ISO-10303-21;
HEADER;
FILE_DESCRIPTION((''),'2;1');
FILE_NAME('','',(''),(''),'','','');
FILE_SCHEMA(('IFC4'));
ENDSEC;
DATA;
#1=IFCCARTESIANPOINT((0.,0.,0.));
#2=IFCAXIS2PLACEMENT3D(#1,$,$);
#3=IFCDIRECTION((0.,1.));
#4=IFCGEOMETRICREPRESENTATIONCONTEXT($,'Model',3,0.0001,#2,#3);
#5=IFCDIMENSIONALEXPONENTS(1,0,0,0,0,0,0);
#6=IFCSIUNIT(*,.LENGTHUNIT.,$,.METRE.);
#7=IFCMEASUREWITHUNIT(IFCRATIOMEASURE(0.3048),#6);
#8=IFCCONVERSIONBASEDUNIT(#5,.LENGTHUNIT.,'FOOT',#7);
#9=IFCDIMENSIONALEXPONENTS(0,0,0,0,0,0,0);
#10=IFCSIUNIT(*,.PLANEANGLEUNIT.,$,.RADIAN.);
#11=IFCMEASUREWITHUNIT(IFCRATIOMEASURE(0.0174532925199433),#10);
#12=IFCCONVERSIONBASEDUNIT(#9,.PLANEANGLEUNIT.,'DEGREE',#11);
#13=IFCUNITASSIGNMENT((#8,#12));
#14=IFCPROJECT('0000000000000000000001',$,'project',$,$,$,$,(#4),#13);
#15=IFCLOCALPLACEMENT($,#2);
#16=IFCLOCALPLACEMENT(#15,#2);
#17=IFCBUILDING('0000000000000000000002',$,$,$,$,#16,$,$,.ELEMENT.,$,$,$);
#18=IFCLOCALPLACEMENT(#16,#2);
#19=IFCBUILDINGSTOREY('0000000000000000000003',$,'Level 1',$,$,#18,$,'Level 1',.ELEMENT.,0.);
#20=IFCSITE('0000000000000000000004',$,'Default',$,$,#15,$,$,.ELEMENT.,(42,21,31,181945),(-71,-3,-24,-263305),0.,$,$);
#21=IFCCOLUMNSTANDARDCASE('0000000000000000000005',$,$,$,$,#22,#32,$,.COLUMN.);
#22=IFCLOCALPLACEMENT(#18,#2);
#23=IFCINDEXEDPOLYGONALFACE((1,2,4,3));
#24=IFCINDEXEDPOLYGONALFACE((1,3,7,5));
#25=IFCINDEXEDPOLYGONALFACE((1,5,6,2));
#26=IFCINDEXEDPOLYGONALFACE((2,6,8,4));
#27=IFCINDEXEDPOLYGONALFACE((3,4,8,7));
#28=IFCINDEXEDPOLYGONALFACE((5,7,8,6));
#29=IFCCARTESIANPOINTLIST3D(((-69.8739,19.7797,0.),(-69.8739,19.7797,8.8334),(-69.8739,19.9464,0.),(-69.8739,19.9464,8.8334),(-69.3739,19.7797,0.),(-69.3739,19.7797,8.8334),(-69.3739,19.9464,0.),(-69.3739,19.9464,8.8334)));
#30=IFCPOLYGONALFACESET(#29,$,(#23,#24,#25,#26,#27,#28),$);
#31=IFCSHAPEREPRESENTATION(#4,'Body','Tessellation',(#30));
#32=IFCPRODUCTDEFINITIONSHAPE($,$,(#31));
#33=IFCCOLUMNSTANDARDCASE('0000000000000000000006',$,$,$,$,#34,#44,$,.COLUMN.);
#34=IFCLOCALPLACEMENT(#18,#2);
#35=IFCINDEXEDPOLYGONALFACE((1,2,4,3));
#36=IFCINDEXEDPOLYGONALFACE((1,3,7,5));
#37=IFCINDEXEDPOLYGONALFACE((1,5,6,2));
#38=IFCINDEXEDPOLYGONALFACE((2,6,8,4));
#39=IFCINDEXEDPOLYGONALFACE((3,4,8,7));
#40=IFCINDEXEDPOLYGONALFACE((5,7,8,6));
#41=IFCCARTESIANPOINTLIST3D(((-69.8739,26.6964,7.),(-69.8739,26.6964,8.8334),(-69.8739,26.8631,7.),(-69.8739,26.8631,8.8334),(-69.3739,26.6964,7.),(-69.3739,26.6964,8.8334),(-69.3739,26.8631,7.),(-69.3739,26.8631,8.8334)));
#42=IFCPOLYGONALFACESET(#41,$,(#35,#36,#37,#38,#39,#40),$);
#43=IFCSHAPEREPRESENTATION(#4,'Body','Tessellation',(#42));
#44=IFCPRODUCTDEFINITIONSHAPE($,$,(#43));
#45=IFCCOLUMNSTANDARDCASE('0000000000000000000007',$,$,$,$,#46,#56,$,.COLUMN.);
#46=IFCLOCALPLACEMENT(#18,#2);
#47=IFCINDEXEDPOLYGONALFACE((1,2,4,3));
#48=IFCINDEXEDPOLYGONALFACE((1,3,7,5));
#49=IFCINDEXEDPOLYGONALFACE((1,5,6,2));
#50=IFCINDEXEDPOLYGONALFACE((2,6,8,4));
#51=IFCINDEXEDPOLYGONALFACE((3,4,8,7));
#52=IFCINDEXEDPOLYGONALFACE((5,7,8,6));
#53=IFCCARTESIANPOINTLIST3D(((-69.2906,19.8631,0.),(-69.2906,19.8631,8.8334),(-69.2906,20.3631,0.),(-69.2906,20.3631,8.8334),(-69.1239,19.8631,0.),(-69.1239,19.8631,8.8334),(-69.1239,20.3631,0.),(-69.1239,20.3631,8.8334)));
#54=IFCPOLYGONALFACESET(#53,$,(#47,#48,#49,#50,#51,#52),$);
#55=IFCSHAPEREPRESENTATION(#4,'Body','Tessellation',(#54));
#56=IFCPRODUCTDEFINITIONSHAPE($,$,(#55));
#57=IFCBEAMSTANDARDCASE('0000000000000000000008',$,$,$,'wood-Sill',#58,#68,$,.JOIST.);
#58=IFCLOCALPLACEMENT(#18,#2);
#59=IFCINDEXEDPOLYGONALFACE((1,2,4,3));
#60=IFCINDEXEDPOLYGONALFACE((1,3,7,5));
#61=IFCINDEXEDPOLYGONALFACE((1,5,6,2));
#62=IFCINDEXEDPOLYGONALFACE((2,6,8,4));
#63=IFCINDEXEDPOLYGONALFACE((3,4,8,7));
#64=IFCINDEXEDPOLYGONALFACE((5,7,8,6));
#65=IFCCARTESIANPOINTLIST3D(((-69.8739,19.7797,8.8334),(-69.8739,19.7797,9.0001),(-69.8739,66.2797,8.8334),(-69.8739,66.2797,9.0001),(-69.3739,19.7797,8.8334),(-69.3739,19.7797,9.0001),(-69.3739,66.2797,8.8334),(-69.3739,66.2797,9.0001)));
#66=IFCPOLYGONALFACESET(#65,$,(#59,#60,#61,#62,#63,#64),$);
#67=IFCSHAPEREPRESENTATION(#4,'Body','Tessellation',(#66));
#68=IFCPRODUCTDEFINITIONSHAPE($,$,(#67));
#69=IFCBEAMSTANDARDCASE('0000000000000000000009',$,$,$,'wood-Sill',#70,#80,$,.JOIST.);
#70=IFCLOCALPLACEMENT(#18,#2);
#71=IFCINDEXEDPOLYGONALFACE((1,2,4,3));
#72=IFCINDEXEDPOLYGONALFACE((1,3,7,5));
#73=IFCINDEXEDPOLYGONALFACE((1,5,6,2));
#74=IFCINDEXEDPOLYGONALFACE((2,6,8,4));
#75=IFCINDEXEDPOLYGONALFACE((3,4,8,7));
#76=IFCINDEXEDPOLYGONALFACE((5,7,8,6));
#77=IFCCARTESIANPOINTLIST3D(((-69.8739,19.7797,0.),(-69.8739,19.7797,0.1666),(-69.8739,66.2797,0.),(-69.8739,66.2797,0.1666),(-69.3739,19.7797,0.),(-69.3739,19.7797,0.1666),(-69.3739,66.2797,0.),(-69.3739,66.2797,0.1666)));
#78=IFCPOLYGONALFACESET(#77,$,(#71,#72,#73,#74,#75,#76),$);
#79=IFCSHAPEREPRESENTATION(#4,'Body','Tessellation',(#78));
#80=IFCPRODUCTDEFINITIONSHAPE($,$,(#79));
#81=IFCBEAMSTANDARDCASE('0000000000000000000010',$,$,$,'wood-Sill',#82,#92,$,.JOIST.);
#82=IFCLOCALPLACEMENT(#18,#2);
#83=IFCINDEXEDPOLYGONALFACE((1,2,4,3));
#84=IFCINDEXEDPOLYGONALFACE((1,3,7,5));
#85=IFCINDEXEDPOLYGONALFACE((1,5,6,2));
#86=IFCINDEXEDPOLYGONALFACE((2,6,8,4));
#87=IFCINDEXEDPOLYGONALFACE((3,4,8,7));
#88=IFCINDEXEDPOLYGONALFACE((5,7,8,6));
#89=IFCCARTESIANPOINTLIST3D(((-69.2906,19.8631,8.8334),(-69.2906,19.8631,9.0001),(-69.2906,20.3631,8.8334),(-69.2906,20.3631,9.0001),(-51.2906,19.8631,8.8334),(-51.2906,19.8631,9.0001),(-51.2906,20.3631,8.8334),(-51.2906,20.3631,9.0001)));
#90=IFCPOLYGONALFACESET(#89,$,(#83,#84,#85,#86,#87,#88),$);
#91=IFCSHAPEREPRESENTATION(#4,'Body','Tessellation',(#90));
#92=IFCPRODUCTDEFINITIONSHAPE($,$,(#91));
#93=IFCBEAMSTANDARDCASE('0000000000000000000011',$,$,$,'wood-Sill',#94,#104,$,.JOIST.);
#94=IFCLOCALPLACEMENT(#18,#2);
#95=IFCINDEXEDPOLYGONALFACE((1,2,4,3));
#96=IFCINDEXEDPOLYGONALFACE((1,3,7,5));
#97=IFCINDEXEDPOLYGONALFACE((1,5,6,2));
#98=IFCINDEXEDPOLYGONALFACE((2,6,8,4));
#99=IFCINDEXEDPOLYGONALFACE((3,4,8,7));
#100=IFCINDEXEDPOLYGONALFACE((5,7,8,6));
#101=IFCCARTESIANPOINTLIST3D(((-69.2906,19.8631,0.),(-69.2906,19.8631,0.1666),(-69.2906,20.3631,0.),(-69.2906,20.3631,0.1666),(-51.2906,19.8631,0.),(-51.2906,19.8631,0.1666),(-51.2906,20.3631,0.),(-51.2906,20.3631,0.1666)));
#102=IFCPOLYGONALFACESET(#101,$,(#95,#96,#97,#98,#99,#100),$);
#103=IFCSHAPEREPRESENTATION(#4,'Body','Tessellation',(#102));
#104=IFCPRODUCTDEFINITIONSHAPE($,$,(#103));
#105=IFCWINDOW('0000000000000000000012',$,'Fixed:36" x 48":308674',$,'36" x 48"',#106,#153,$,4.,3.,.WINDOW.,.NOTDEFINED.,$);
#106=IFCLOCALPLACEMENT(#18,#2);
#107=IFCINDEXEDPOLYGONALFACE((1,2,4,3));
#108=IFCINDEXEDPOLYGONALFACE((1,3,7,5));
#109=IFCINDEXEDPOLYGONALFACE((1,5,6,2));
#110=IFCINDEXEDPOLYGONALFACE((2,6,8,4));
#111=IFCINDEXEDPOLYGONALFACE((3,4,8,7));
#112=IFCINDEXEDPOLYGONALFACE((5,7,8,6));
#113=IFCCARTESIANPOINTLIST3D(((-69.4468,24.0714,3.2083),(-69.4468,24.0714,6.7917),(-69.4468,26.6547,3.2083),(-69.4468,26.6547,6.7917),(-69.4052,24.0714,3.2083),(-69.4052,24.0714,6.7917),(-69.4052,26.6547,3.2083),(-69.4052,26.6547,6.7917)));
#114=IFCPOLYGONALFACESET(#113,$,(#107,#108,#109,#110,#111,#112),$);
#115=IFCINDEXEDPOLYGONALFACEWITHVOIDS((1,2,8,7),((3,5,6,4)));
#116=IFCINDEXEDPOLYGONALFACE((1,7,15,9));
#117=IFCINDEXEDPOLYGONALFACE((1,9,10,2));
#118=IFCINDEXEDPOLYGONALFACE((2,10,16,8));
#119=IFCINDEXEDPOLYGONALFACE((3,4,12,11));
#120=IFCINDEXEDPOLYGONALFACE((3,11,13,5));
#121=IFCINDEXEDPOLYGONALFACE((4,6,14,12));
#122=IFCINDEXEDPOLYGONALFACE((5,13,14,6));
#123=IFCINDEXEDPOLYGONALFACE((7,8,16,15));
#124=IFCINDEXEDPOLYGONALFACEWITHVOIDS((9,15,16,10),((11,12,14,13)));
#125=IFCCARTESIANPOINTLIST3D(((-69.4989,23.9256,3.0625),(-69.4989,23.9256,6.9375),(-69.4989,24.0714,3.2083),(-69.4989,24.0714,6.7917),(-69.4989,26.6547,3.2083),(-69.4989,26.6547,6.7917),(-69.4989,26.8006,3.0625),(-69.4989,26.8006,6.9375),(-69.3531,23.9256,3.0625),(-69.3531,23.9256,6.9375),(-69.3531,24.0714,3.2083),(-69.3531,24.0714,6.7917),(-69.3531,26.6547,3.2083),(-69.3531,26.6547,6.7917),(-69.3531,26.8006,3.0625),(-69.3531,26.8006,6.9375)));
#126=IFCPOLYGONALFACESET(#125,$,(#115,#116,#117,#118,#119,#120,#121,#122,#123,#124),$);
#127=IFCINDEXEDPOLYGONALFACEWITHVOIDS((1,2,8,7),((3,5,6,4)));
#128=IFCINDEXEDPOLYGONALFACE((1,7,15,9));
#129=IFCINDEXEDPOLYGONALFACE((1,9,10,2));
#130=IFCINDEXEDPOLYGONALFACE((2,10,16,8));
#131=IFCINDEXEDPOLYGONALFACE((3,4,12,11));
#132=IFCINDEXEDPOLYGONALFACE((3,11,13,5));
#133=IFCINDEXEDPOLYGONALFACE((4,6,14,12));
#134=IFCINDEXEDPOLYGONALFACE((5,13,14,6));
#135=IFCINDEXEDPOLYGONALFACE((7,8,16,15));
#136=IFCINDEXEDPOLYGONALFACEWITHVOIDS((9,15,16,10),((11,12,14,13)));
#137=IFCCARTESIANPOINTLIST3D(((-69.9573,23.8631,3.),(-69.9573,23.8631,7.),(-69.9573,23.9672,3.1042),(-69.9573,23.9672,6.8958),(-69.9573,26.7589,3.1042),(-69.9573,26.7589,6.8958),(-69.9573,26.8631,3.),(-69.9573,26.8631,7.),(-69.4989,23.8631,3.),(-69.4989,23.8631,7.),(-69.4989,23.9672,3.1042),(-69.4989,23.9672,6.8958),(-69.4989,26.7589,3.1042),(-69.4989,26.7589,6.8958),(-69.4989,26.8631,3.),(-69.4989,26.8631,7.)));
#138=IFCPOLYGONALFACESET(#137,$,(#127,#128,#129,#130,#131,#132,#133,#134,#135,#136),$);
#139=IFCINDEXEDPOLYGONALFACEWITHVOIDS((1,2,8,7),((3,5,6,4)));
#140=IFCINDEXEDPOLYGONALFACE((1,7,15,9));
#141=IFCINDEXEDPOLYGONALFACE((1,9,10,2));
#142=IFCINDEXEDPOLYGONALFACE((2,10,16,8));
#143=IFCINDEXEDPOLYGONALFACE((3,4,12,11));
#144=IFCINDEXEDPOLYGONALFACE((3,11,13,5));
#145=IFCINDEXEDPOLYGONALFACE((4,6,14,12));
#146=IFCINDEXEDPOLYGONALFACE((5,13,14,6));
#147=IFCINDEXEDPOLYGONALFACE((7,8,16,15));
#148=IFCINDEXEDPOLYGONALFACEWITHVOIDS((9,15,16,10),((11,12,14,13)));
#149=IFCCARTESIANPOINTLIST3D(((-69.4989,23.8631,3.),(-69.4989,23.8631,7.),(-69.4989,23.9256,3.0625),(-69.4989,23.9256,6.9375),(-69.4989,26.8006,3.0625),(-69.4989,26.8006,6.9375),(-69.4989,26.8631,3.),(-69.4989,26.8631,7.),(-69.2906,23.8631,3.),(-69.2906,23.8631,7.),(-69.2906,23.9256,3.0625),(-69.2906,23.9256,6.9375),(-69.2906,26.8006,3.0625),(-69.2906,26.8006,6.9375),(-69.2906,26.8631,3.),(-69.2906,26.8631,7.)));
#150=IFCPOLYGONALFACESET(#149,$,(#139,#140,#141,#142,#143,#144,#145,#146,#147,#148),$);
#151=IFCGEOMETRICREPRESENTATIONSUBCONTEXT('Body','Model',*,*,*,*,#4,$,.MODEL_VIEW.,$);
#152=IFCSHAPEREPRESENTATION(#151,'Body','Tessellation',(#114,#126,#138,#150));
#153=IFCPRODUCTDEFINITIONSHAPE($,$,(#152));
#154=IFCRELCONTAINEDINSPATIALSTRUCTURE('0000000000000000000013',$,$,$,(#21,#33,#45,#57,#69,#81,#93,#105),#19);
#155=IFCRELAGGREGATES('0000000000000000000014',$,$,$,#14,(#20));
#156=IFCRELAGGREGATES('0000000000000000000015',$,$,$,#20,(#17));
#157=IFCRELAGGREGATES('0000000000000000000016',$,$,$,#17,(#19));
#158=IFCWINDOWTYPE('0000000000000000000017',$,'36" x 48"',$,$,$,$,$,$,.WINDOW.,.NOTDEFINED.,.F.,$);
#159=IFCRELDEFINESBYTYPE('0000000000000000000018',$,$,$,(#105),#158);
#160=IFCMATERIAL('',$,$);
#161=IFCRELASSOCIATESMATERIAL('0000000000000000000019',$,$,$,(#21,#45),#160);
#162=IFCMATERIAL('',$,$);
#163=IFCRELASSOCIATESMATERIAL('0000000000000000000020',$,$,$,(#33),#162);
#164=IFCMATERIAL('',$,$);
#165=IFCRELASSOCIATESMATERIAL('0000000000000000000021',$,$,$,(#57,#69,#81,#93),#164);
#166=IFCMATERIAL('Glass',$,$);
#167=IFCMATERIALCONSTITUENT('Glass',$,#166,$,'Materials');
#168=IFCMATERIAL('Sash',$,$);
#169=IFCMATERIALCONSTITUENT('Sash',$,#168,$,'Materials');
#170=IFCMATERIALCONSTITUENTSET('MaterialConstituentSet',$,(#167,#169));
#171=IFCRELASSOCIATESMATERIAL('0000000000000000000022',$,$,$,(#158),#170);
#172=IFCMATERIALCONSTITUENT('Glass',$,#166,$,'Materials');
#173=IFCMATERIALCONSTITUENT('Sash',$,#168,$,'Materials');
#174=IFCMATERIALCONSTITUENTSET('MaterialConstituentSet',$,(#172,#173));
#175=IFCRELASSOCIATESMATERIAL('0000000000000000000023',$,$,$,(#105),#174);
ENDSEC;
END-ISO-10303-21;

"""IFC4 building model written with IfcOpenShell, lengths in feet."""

from ifc_helpers import new_model, entity, si_unit, converted_unit, direction, frame, frame_2d, origin, origin_with_axes, place, context, subcontext, project, spatial, polyline, rectangle, outline, extrude, source, transform, mapped, material, constituent, constituent_set, type_object, type_shapes, element, save


model = new_model("IFC4")

# Units and contexts
model_context = context("Model", 3, precision=0.0001, world=origin(), true_north=direction((0.0, 1.0)))
body_context = subcontext(model_context, "Body", "Model", "MODEL_VIEW")
ifc_project = project(units=[converted_unit("LENGTHUNIT", "FOOT", entity("IfcRatioMeasure", 0.3048), si_unit("LENGTHUNIT", "METRE"), dimensions=[1, 0, 0, 0, 0, 0, 0]), converted_unit("PLANEANGLEUNIT", "DEGREE", entity("IfcRatioMeasure", 0.0174532925199433), si_unit("PLANEANGLEUNIT", "RADIAN"), dimensions=[0, 0, 0, 0, 0, 0, 0])], contexts=[model_context])

# Site, building, storey
site_placement = place(None, origin())
site = spatial("IfcSite", under=ifc_project, at=site_placement, Name="Default", CompositionType="ELEMENT", RefLatitude=(42, 21, 31, 181945), RefLongitude=(-71, -3, -24, -263305), RefElevation=0.0)
building_placement = place(site_placement, origin())
building = spatial("IfcBuilding", under=site, at=building_placement, CompositionType="ELEMENT")
storey_placement = place(building_placement, origin())
storey = spatial("IfcBuildingStorey", under=building, at=storey_placement, Name="Level 1", LongName="Level 1", CompositionType="ELEMENT", Elevation=0.0)

# Columns
ifc_material_1 = material(Name="")
placement_1 = place(storey_placement, frame((-69.6239, 19.7797, 0.0), z_axis=(0.0, 0.0, 1.0), x_axis=(0.0, 1.0, 0.0)))
for number, where, z_axis, x_axis in (
    (1, (0.0833, 0.0, 0.0), (0.0, 0.0, 1.0), (1.0, 0.0, 0.0)),
):
    element("IfcColumnStandardCase", number, at=place(placement_1, frame(where, z_axis=z_axis, x_axis=x_axis)), inside=storey, material=ifc_material_1, PredefinedType="COLUMN", context=model_context, shape_type="SweptSolid", body=[
        extrude(rectangle(XDim=0.1667, YDim=0.5), origin(), (0.0, 0.0, 1.0), 8.8334),
    ])
ifc_material_2 = material(Name="")
for number, where, z_axis, x_axis in (
    (2, (7.0, 0.0, 7.0), (0.0, 0.0, 1.0), (1.0, 0.0, 0.0)),
):
    element("IfcColumnStandardCase", number, at=place(placement_1, frame(where, z_axis=z_axis, x_axis=x_axis)), inside=storey, material=ifc_material_2, PredefinedType="COLUMN", context=model_context, shape_type="SweptSolid", body=[
        extrude(rectangle(XDim=0.1667, YDim=0.5), origin(), (0.0, 0.0, 1.0), 1.8334),
    ])
placement_2 = place(storey_placement, frame((-69.2906, 20.1131, 0.0)))
for number, where, z_axis, x_axis in (
    (3, (0.0833, 0.0, 0.0), (0.0, 0.0, 1.0), (1.0, 0.0, 0.0)),
):
    element("IfcColumnStandardCase", number, at=place(placement_2, frame(where, z_axis=z_axis, x_axis=x_axis)), inside=storey, material=ifc_material_1, PredefinedType="COLUMN", context=model_context, shape_type="SweptSolid", body=[
        extrude(rectangle(XDim=0.1667, YDim=0.5), origin(), (0.0, 0.0, 1.0), 8.8334),
    ])

# Beams
ifc_material_3 = material(Name="")
for number, where, z_axis, x_axis in (
    (4, (0.0, 0.0, 8.9167), (1.0, 0.0, 0.0), (0.0, 0.0, 1.0)),
    (5, (0.0, 0.0, 0.0833), (1.0, 0.0, 0.0), (0.0, 0.0, 1.0)),
):
    element("IfcBeamStandardCase", number, at=place(placement_1, frame(where, z_axis=z_axis, x_axis=x_axis)), inside=storey, material=ifc_material_3, ObjectType="wood-Sill", PredefinedType="JOIST", context=model_context, shape_type="SweptSolid", body=[
        extrude(rectangle(XDim=0.1667, YDim=0.5), origin_with_axes(), (0.0, 0.0, 1.0), 46.5),
    ])
for number, where, z_axis, x_axis in (
    (6, (0.0, 0.0, 8.9167), (1.0, 0.0, 0.0), (0.0, 0.0, 1.0)),
    (7, (0.0, 0.0, 0.0833), (1.0, 0.0, 0.0), (0.0, 0.0, 1.0)),
):
    element("IfcBeamStandardCase", number, at=place(placement_2, frame(where, z_axis=z_axis, x_axis=x_axis)), inside=storey, material=ifc_material_3, ObjectType="wood-Sill", PredefinedType="JOIST", context=model_context, shape_type="SweptSolid", body=[
        extrude(rectangle(XDim=0.1667, YDim=0.5), origin_with_axes(), (0.0, 0.0, 1.0), 18.0),
    ])

# Window
ifc_material_4 = material(Name="Glass")
ifc_constituent_1 = constituent(ifc_material_4, Name="Glass", Category="Materials")
ifc_material_5 = material(Name="Sash")
ifc_constituent_2 = constituent(ifc_material_5, Name="Sash", Category="Materials")
ifc_constituent_set_1 = constituent_set(constituents=[ifc_constituent_1, ifc_constituent_2], Name="MaterialConstituentSet")
ifc_constituent_3 = constituent(ifc_material_4, Name="Glass", Category="Materials")
ifc_constituent_4 = constituent(ifc_material_5, Name="Sash", Category="Materials")
ifc_constituent_set_2 = constituent_set(constituents=[ifc_constituent_3, ifc_constituent_4], Name="MaterialConstituentSet")
window_type = type_object("IfcWindowType", Name="36\" x 48\"", ParameterTakesPrecedence=False, PartitioningType="NOTDEFINED", PredefinedType="WINDOW", material=ifc_constituent_set_2)
shared_shape = source(origin(), body_context, "Body", "SweptSolid", [
    extrude(rectangle(XDim=2.5833, YDim=0.0417, at=frame_2d((0.0, 0.0), x_axis=(1.0, 0.0))), frame((1.75, 0.5312, 0.2083)), (0.0, 0.0, 1.0), 3.5833),
    extrude(outline(polyline([(-1.4375, -1.9375), (1.4375, -1.9375), (1.4375, 1.9375), (-1.4375, 1.9375), (-1.4375, -1.9375)]), holes=[polyline([(-1.2917, -1.7917), (-1.2917, 1.7917), (1.2917, 1.7917), (1.2917, -1.7917), (-1.2917, -1.7917)])]), frame((1.75, 0.6042, 2.0), z_axis=(0.0, -1.0, 0.0), x_axis=(-1.0, 0.0, 0.0)), (0.0, 0.0, 1.0), 0.1458),
    extrude(outline(polyline([(-1.5, -2.0), (1.5, -2.0), (1.5, 2.0), (-1.5, 2.0), (-1.5, -2.0)]), holes=[polyline([(-1.3958, -1.8958), (-1.3958, 1.8958), (1.3958, 1.8958), (1.3958, -1.8958), (-1.3958, -1.8958)])]), frame((1.75, 0.4583, 2.0), z_axis=(0.0, -1.0, 0.0), x_axis=(-1.0, 0.0, 0.0)), (0.0, 0.0, 1.0), 0.4583),
    extrude(outline(polyline([(-2.0, -1.5), (2.0, -1.5), (2.0, 1.5), (-2.0, 1.5), (-2.0, -1.5)]), holes=[polyline([(-1.9375, -1.4375), (-1.9375, 1.4375), (1.9375, 1.4375), (1.9375, -1.4375), (-1.9375, -1.4375)])]), frame((1.75, 0.6667, 2.0), z_axis=(0.0, -1.0, 0.0), x_axis=(0.0, 0.0, -1.0)), (0.0, 0.0, 1.0), 0.2083),
])
type_shapes(window_type, [shared_shape])
placement_3 = place(placement_1, frame((7.0833, 0.3333, 3.0)))
window_placement = place(placement_3, frame((0.25, 0.0, 0.0), z_axis=(0.0, 0.0, 1.0), x_axis=(-1.0, 0.0, 0.0)))
element("IfcWindow", 8, at=window_placement, inside=storey, type_object=window_type, material=ifc_constituent_set_1, Name="Fixed:36\" x 48\":308674", ObjectType="36\" x 48\"", OverallHeight=4.0, OverallWidth=3.0, PartitioningType="NOTDEFINED", PredefinedType="WINDOW", context=body_context, shape_type="MappedRepresentation", body=[
    mapped(shared_shape, transform((0.0, 0.0, 0.0), scale=1.0)),
])

save(model, "model.ifc")
